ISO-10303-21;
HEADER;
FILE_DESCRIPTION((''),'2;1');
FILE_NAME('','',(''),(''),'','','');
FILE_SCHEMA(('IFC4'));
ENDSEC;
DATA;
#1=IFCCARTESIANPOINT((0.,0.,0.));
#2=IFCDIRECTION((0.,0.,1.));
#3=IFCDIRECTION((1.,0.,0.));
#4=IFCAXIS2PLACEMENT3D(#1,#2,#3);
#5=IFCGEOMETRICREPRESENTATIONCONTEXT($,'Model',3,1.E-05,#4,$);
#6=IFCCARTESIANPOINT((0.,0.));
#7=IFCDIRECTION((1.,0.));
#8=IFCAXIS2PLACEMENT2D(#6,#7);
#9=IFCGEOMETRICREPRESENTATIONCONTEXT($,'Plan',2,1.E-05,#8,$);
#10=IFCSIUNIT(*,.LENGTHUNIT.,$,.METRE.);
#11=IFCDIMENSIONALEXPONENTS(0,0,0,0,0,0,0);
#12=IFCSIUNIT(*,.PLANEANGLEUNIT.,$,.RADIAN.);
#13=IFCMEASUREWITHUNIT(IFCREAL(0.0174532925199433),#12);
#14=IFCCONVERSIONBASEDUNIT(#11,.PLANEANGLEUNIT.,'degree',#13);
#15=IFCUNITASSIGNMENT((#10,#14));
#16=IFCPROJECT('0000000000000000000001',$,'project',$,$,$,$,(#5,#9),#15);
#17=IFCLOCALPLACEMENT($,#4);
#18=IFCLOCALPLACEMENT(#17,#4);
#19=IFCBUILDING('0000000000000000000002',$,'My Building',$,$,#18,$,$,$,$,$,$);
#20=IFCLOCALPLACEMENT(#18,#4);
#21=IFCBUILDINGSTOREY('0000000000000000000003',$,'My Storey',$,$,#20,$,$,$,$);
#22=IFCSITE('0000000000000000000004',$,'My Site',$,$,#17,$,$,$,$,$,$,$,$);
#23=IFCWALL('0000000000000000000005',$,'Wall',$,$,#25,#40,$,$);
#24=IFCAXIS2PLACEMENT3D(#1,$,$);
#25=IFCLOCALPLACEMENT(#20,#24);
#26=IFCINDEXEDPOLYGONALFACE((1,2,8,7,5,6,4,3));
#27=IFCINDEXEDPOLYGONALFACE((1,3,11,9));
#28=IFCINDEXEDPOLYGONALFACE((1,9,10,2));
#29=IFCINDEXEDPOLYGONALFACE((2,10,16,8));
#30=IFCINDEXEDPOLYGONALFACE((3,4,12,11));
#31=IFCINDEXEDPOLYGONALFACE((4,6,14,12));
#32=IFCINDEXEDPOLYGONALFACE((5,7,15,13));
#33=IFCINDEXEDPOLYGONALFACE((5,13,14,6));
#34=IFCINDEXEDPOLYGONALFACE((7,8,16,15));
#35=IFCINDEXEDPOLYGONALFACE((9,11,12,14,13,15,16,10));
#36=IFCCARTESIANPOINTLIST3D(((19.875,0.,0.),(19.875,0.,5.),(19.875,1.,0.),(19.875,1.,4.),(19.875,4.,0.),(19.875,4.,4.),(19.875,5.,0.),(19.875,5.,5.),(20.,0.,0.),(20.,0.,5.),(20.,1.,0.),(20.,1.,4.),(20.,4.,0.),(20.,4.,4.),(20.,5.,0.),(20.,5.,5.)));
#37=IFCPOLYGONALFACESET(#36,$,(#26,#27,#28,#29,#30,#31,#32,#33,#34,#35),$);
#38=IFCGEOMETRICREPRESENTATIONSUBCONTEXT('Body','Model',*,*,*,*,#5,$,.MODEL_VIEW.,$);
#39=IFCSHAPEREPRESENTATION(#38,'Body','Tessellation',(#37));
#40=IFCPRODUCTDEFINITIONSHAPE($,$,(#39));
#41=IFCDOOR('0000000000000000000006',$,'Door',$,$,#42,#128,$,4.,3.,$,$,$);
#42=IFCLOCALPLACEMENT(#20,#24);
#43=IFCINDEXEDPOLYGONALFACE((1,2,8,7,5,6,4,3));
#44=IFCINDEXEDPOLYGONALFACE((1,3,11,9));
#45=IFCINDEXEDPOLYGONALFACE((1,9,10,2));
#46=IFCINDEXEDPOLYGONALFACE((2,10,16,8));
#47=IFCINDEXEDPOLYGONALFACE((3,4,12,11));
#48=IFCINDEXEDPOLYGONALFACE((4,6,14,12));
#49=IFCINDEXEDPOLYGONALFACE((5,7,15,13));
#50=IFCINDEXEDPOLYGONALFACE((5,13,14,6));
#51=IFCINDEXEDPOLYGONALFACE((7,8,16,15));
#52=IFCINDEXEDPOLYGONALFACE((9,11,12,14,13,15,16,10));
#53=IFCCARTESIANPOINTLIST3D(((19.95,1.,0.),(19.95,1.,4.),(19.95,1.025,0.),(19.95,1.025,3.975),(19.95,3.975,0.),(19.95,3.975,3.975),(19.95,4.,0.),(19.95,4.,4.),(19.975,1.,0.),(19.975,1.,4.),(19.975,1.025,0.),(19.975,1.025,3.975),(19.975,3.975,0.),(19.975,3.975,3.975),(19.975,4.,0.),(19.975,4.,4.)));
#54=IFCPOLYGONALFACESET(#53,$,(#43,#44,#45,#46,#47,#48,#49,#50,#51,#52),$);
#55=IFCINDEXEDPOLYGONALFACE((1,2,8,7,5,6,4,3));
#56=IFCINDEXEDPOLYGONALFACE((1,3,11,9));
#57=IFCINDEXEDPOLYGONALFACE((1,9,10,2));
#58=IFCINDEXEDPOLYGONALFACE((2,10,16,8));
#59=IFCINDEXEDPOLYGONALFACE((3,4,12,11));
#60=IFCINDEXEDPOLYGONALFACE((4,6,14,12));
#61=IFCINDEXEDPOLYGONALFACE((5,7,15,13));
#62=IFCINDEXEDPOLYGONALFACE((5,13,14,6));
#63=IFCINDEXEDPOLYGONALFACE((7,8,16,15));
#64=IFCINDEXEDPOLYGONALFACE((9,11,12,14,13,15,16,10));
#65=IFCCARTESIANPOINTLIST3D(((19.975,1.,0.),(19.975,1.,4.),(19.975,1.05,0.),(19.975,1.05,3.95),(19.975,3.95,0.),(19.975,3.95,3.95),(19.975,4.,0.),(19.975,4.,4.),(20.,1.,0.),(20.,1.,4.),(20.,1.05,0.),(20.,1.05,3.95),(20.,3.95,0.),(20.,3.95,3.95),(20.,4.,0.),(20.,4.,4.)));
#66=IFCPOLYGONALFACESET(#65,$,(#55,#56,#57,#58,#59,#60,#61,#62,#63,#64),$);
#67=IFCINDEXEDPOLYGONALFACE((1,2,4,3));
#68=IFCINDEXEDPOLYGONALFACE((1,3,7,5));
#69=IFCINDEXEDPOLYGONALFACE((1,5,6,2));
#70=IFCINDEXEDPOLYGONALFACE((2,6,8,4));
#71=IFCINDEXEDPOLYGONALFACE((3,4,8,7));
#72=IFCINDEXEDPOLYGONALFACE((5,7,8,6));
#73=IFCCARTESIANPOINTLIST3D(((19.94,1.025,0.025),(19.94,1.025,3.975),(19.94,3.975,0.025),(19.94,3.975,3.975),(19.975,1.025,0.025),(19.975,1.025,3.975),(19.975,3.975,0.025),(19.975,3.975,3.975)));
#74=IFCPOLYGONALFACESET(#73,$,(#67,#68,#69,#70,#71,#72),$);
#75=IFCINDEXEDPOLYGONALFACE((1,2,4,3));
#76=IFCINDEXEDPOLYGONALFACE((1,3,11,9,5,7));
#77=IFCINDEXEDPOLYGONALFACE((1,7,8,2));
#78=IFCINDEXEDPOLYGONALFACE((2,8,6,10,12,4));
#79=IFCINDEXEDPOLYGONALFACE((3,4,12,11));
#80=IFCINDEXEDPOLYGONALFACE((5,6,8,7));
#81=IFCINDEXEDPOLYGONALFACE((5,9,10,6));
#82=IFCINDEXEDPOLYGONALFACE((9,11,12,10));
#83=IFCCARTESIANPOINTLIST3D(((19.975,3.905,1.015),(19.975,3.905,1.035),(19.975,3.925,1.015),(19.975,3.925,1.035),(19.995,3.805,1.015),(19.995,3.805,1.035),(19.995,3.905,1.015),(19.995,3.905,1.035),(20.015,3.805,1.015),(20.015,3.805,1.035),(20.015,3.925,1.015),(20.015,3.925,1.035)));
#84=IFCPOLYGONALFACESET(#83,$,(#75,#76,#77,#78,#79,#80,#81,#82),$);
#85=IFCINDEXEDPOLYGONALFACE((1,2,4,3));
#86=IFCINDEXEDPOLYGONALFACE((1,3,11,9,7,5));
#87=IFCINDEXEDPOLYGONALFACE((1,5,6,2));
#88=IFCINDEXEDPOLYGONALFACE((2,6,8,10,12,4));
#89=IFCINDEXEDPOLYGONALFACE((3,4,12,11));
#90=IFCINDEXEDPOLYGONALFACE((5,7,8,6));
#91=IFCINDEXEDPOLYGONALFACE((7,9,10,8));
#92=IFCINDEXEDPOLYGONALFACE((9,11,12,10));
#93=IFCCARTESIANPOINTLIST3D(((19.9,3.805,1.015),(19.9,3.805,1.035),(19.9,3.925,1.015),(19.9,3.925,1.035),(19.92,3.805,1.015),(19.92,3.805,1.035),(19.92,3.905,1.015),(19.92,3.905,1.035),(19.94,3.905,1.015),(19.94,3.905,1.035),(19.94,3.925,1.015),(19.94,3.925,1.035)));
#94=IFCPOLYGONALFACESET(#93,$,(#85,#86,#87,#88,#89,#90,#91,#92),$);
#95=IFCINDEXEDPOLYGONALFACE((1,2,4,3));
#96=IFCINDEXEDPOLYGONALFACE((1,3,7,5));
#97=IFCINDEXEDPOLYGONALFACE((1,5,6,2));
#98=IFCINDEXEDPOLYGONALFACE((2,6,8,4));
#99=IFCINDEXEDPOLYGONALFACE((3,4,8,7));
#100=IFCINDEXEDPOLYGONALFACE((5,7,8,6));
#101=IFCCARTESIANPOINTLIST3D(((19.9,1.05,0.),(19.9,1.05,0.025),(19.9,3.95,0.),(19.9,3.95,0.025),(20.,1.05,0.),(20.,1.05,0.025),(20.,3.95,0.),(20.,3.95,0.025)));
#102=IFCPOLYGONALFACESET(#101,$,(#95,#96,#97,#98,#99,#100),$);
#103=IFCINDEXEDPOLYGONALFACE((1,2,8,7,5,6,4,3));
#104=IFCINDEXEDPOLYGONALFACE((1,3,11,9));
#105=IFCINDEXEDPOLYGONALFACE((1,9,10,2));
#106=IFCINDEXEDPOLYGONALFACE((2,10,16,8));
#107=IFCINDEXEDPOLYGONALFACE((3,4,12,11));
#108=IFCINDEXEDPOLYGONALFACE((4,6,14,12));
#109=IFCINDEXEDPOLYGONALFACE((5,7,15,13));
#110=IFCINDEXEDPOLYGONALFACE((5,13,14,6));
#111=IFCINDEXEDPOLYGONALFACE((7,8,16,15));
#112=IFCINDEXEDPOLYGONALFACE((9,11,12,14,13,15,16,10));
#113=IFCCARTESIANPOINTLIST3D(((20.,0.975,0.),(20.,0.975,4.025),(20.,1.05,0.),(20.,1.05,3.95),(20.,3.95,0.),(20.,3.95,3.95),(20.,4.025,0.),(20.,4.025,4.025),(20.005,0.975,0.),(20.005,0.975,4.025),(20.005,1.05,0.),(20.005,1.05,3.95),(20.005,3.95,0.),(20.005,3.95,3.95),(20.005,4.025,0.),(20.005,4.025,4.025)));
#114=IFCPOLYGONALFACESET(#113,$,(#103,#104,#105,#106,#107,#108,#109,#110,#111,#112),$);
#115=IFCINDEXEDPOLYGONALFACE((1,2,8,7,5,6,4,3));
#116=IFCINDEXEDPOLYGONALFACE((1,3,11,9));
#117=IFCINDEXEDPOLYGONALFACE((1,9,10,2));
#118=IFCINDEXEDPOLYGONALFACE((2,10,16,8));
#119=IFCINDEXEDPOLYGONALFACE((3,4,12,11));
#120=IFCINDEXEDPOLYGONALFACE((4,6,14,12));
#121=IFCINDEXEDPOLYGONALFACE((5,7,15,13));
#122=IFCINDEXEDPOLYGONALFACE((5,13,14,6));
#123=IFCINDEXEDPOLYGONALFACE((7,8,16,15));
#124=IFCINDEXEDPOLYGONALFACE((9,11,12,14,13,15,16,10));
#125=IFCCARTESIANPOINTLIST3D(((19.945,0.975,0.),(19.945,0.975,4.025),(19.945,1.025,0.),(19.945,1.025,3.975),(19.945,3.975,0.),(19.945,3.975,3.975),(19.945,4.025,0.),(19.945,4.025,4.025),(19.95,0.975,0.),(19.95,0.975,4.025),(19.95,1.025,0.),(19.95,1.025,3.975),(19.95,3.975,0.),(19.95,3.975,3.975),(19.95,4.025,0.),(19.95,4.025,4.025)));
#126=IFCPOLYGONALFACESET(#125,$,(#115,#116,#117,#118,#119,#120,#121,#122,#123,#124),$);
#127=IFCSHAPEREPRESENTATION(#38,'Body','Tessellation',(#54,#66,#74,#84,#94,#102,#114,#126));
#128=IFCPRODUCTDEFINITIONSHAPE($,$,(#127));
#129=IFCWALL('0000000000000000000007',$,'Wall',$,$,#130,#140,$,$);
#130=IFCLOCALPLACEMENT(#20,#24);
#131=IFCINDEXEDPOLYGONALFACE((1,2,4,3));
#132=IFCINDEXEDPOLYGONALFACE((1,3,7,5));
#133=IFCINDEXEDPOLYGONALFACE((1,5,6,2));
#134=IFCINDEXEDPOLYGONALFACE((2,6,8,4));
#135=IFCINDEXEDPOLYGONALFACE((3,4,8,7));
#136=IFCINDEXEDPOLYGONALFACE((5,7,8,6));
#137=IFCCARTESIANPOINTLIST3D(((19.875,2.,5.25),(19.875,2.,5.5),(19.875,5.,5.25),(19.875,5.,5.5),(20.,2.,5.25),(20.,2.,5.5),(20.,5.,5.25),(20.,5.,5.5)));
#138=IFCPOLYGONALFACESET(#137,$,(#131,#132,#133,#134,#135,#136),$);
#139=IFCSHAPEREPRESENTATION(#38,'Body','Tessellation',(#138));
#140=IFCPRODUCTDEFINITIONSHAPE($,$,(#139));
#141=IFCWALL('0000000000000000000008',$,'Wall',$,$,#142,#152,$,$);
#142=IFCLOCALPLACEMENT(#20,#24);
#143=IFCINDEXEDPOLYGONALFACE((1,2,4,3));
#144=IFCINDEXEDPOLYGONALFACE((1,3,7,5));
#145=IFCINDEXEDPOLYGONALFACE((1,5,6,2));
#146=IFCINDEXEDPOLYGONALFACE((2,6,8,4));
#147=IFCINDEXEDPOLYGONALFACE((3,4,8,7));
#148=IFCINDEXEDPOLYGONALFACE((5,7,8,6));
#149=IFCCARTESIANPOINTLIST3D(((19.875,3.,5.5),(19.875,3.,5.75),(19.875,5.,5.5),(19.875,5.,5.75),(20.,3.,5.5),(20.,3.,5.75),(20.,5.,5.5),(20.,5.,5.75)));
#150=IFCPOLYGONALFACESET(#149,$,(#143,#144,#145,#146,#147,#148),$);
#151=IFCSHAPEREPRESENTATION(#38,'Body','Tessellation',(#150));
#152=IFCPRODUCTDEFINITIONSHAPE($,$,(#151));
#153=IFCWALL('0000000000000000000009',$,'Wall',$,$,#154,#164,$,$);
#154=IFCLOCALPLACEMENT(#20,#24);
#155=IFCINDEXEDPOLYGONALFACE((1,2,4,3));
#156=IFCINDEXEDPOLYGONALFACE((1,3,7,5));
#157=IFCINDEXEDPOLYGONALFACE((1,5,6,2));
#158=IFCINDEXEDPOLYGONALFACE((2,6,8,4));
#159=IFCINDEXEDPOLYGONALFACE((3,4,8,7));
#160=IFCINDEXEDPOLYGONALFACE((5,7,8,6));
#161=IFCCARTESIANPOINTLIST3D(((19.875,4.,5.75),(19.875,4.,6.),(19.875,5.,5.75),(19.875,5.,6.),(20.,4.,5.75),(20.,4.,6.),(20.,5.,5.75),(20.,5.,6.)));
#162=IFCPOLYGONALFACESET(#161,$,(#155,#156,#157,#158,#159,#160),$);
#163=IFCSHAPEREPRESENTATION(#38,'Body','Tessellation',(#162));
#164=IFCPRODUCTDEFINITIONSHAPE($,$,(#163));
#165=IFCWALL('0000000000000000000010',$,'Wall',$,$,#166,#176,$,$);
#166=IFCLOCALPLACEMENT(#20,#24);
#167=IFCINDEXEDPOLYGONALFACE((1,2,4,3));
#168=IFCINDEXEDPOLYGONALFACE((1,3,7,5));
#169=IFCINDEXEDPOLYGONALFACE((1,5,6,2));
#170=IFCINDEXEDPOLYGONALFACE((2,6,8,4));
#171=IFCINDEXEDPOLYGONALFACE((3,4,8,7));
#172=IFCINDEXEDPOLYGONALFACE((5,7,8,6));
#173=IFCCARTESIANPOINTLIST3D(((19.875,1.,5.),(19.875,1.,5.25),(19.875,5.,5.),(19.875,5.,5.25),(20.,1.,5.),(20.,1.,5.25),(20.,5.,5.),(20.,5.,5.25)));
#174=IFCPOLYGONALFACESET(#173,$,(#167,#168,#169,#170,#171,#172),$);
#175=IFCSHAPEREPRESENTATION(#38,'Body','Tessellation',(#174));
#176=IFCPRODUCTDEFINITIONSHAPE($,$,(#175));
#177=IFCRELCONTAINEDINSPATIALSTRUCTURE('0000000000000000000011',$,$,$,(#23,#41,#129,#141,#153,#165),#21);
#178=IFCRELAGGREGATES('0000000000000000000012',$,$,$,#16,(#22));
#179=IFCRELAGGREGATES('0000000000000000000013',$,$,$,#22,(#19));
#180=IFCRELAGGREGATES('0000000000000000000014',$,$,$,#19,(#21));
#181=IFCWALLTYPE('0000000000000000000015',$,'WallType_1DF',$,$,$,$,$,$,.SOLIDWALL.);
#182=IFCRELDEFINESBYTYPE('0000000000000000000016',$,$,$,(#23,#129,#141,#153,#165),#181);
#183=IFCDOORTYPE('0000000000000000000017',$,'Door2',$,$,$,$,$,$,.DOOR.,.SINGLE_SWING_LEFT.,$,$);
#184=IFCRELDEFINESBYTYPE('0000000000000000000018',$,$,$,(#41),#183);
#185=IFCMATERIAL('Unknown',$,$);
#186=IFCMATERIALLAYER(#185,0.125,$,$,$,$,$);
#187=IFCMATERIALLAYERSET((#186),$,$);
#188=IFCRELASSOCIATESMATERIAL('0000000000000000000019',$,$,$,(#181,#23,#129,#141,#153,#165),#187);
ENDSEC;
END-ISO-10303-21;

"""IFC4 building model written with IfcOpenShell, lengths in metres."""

from ifc_helpers import new_model, entity, si_unit, converted_unit, frame, origin_with_axes, origin_2d_with_axis, place, context, subcontext, project, spatial, line, indexed_curve, outline, extrude, shape, source, transform, mapped, material, layer, layer_set, layer_usage, type_object, type_shapes, element, fill, save


model = new_model("IFC4")

# Units and contexts
model_context = context("Model", 3, precision=1e-05, world=origin_with_axes())
plan_context = context("Plan", 2, precision=1e-05, world=origin_2d_with_axis())
body_context_1 = subcontext(model_context, "Body", "Model", "MODEL_VIEW")
body_context_2 = subcontext(plan_context, "Body", "Plan", "PLAN_VIEW")
ifc_project = project(units=[si_unit("LENGTHUNIT", "METRE"), converted_unit("PLANEANGLEUNIT", "degree", entity("IfcReal", 0.0174532925199433), si_unit("PLANEANGLEUNIT", "RADIAN"), dimensions=[0, 0, 0, 0, 0, 0, 0])], contexts=[model_context, plan_context])

# Site, building, storey
site_placement = place(None, origin_with_axes())
site = spatial("IfcSite", under=ifc_project, at=site_placement, Name="My Site")
building_placement = place(site_placement, origin_with_axes())
building = spatial("IfcBuilding", under=site, at=building_placement, Name="My Building")
storey_placement = place(building_placement, origin_with_axes())
storey = spatial("IfcBuildingStorey", under=building, at=storey_placement, Name="My Storey")

# Wall, opening, door
ifc_material = material(Name="Unknown")
ifc_layer_1 = layer(ifc_material, 0.125)
ifc_layer_set_1 = layer_set([ifc_layer_1])
ifc_layer_usage_1 = layer_usage(ifc_layer_set_1, "AXIS2", "POSITIVE", 0.0)
wall_type_1 = type_object("IfcWallType", Name="WallType_1DF", PredefinedType="SOLIDWALL", material=ifc_layer_set_1)
wall_1_placement = place(storey_placement, frame((20.0, 0.0, 0.0), z_axis=(0.0, 0.0, 1.0), x_axis=(0.0, 1.0, 0.0)))
wall_1 = element("IfcWall", 1, at=wall_1_placement, inside=storey, type_object=wall_type_1, material=ifc_layer_usage_1, Name="Wall", context=body_context_1, shape_type="SweptSolid", body=[
    extrude(outline(indexed_curve([(0.0, 0.0), (0.0, 0.125), (5.0, 0.125), (5.0, 0.0), (0.0, 0.0)], self_intersect=False)), origin_with_axes(), (0.0, 0.0, 1.0), 5.0),
])
shared_shape_1 = source(origin_with_axes(), body_context_1, "Body", "SweptSolid", [
    extrude(outline(indexed_curve([(0.0, 0.0), (3.0, 0.0), (3.0, 4.0), (0.0, 4.0)], segments=[line(1, 2, 3, 4, 1)])), frame((0.0, -0.1, 0.0), z_axis=(0.0, -1.0, 0.0), x_axis=(1.0, 0.0, 0.0)), (0.0, 0.0, -1.0), 0.45),
])
opening_placement = place(wall_1_placement, frame((1.0, 0.0, 0.0), z_axis=(0.0, 0.0, 1.0), x_axis=(1.0, 0.0, 0.0)))
opening = element("IfcOpeningElement", 2, at=opening_placement, cuts=wall_1, PredefinedType="OPENING", context=body_context_1, shape_type="MappedRepresentation", body=[
    mapped(shared_shape_1, transform((0.0, 0.0, 0.0), x_axis=(1.0, 0.0, 0.0), y_axis=(0.0, 1.0, 0.0), z_axis=(0.0, 0.0, 1.0), scale=1.0)),
])
door_type = type_object("IfcDoorType", Name="Door2", OperationType="SINGLE_SWING_LEFT", PredefinedType="DOOR")
shared_shape_2 = source(origin_with_axes(), body_context_1, "Body", "SweptSolid", [
    extrude(outline(indexed_curve([(0.0, 0.0), (0.0, 4.0), (3.0, 4.0), (3.0, 0.0), (2.975, 0.0), (2.975, 3.975), (0.025, 3.975), (0.025, 0.0)], segments=[line(1, 2, 3, 4, 5, 6, 7, 8, 1)])), frame((0.0, 0.025, 0.0), z_axis=(0.0, -1.0, 0.0), x_axis=(1.0, 0.0, 0.0)), (0.0, 0.0, -1.0), 0.025),
    extrude(outline(indexed_curve([(0.0, 0.0), (0.0, 4.0), (3.0, 4.0), (3.0, 0.0), (2.95, 0.0), (2.95, 3.95), (0.05, 3.95), (0.05, 0.0)], segments=[line(1, 2, 3, 4, 5, 6, 7, 8, 1)])), frame((0.0, 0.0, 0.0), z_axis=(0.0, -1.0, 0.0), x_axis=(1.0, 0.0, 0.0)), (0.0, 0.0, -1.0), 0.025),
    extrude(outline(indexed_curve([(0.0, 0.0), (2.95, 0.0), (2.95, 0.035), (0.0, 0.035)], segments=[line(1, 2, 3, 4, 1)])), frame((0.025, 0.025, 0.025), z_axis=(0.0, 0.0, 1.0), x_axis=(1.0, 0.0, 0.0)), (0.0, 0.0, 1.0), 3.95),
    extrude(outline(indexed_curve([(0.0, 0.0), (0.0, -0.04), (-0.12, -0.04), (-0.12, -0.02), (-0.02, -0.02), (-0.02, 0.0)], segments=[line(1, 2, 3, 4, 5, 6, 1)])), frame((2.925, 0.025, 1.015), z_axis=(0.0, 0.0, 1.0), x_axis=(1.0, 0.0, 0.0)), (0.0, 0.0, 1.0), 0.02),
    extrude(outline(indexed_curve([(0.0, 0.0), (0.0, 0.04), (-0.12, 0.04), (-0.12, 0.02), (-0.02, 0.02), (-0.02, 0.0)], segments=[line(1, 2, 3, 4, 5, 6, 1)])), frame((2.925, 0.06, 1.015), z_axis=(0.0, 0.0, 1.0), x_axis=(1.0, 0.0, 0.0)), (0.0, 0.0, 1.0), 0.02),
    extrude(outline(indexed_curve([(0.0, 0.0), (2.9, 0.0), (2.9, 0.1), (0.0, 0.1)], segments=[line(1, 2, 3, 4, 1)])), frame((0.05, 0.0, 0.0), z_axis=(0.0, 0.0, 1.0), x_axis=(1.0, 0.0, 0.0)), (0.0, 0.0, 1.0), 0.025),
    extrude(outline(indexed_curve([(0.0, 0.0), (0.0, 4.025), (3.05, 4.025), (3.05, 0.0), (2.975, 0.0), (2.975, 3.95), (0.075, 3.95), (0.075, 0.0)], segments=[line(1, 2, 3, 4, 5, 6, 7, 8, 1)])), frame((-0.025, -0.005, 0.0), z_axis=(0.0, -1.0, 0.0), x_axis=(1.0, 0.0, 0.0)), (0.0, 0.0, -1.0), 0.005),
    extrude(outline(indexed_curve([(0.0, 0.0), (0.0, 4.025), (3.05, 4.025), (3.05, 0.0), (3.0, 0.0), (3.0, 3.975), (0.05, 3.975), (0.05, 0.0)], segments=[line(1, 2, 3, 4, 5, 6, 7, 8, 1)])), frame((-0.025, 0.05, 0.0), z_axis=(0.0, -1.0, 0.0), x_axis=(1.0, 0.0, 0.0)), (0.0, 0.0, -1.0), 0.005),
])
shared_shape_3 = source(origin_with_axes(), body_context_2, "Body", "Curve2D", [
    entity("IfcIndexedPolyCurve", entity("IfcCartesianPointList2D", [[0.0, 0.0], [0.0, 0.05], [0.025, 0.05], [0.025, 0.025], [0.05, 0.025], [0.05, 0.0]]), [entity("IfcLineIndex", [1, 2, 3, 4, 5, 6, 1])]),
    entity("IfcIndexedPolyCurve", entity("IfcCartesianPointList2D", [[3.0, 0.0], [3.0, 0.05], [2.975, 0.05], [2.975, 0.025], [2.95, 0.025], [2.95, 0.0]]), [entity("IfcLineIndex", [1, 2, 3, 4, 5, 6, 1])]),
    entity("IfcTrimmedCurve", entity("IfcEllipse", entity("IfcAxis2Placement2D", entity("IfcCartesianPoint", [0.06, 0.05]), entity("IfcDirection", [1.0, 0.0])), 2.915, 2.95), [entity("IfcCartesianPoint", [2.975, 0.05])], [entity("IfcCartesianPoint", [0.06, 3.0])], True, "CARTESIAN"),
    entity("IfcIndexedPolyCurve", entity("IfcCartesianPointList2D", [[0.025, 0.05], [0.06, 0.05], [0.06, 3.0], [0.025, 3.0]]), [entity("IfcLineIndex", [1, 2, 3, 4, 1])]),
])
type_shapes(door_type, [shared_shape_2, shared_shape_3])
door_placement = place(opening_placement, frame((0.0, 0.0, 0.0), z_axis=(0.0, 0.0, 1.0), x_axis=(1.0, 0.0, 0.0)))
door = element("IfcDoor", 3, at=door_placement, inside=storey, type_object=door_type, Name="Door", OverallHeight=4.0, OverallWidth=3.0, shapes=[
    shape(body_context_1, "Body", "MappedRepresentation", [mapped(shared_shape_2, transform((0.0, 0.0, 0.0), x_axis=(1.0, 0.0, 0.0), y_axis=(0.0, 1.0, 0.0), z_axis=(0.0, 0.0, 1.0), scale=1.0))]),
    shape(body_context_2, "Body", "MappedRepresentation", [mapped(shared_shape_3, transform((0.0, 0.0, 0.0), x_axis=(1.0, 0.0, 0.0), y_axis=(0.0, 1.0, 0.0), z_axis=(0.0, 0.0, 1.0), scale=1.0))]),
])
fill(opening, door)

# Walls
ifc_layer_usage_2 = layer_usage(ifc_layer_set_1, "AXIS2", "POSITIVE", 0.0)
wall_2_placement = place(storey_placement, frame((20.0, 2.0, 5.25), z_axis=(0.0, 0.0, 1.0), x_axis=(0.0, 1.0, 0.0)))
element("IfcWall", 4, at=wall_2_placement, inside=storey, type_object=wall_type_1, material=ifc_layer_usage_2, Name="Wall", context=body_context_1, shape_type="SweptSolid", body=[
    extrude(outline(indexed_curve([(0.0, 0.0), (0.0, 0.125), (3.0, 0.125), (3.0, 0.0), (0.0, 0.0)], self_intersect=False)), origin_with_axes(), (0.0, 0.0, 1.0), 0.25),
])
ifc_layer_usage_3 = layer_usage(ifc_layer_set_1, "AXIS2", "POSITIVE", 0.0)
wall_3_placement = place(storey_placement, frame((20.0, 3.0, 5.5), z_axis=(0.0, 0.0, 1.0), x_axis=(0.0, 1.0, 0.0)))
element("IfcWall", 5, at=wall_3_placement, inside=storey, type_object=wall_type_1, material=ifc_layer_usage_3, Name="Wall", context=body_context_1, shape_type="SweptSolid", body=[
    extrude(outline(indexed_curve([(0.0, 0.0), (0.0, 0.125), (2.0, 0.125), (2.0, 0.0), (0.0, 0.0)], self_intersect=False)), origin_with_axes(), (0.0, 0.0, 1.0), 0.25),
])
ifc_layer_usage_4 = layer_usage(ifc_layer_set_1, "AXIS2", "POSITIVE", 0.0)
wall_4_placement = place(storey_placement, frame((20.0, 4.0, 5.75), z_axis=(0.0, 0.0, 1.0), x_axis=(0.0, 1.0, 0.0)))
element("IfcWall", 6, at=wall_4_placement, inside=storey, type_object=wall_type_1, material=ifc_layer_usage_4, Name="Wall", context=body_context_1, shape_type="SweptSolid", body=[
    extrude(outline(indexed_curve([(0.0, 0.0), (0.0, 0.125), (1.0, 0.125), (1.0, 0.0), (0.0, 0.0)], self_intersect=False)), origin_with_axes(), (0.0, 0.0, 1.0), 0.25),
])
ifc_layer_usage_5 = layer_usage(ifc_layer_set_1, "AXIS2", "POSITIVE", 0.0)
wall_5_placement = place(storey_placement, frame((20.0, 1.0, 5.0), z_axis=(0.0, 0.0, 1.0), x_axis=(0.0, 1.0, 0.0)))
element("IfcWall", 7, at=wall_5_placement, inside=storey, type_object=wall_type_1, material=ifc_layer_usage_5, Name="Wall", context=body_context_1, shape_type="SweptSolid", body=[
    extrude(outline(indexed_curve([(0.0, 0.0), (0.0, 0.125), (4.0, 0.125), (4.0, 0.0), (0.0, 0.0)], self_intersect=False)), origin_with_axes(), (0.0, 0.0, 1.0), 0.25),
])

save(model, "model.ifc")
